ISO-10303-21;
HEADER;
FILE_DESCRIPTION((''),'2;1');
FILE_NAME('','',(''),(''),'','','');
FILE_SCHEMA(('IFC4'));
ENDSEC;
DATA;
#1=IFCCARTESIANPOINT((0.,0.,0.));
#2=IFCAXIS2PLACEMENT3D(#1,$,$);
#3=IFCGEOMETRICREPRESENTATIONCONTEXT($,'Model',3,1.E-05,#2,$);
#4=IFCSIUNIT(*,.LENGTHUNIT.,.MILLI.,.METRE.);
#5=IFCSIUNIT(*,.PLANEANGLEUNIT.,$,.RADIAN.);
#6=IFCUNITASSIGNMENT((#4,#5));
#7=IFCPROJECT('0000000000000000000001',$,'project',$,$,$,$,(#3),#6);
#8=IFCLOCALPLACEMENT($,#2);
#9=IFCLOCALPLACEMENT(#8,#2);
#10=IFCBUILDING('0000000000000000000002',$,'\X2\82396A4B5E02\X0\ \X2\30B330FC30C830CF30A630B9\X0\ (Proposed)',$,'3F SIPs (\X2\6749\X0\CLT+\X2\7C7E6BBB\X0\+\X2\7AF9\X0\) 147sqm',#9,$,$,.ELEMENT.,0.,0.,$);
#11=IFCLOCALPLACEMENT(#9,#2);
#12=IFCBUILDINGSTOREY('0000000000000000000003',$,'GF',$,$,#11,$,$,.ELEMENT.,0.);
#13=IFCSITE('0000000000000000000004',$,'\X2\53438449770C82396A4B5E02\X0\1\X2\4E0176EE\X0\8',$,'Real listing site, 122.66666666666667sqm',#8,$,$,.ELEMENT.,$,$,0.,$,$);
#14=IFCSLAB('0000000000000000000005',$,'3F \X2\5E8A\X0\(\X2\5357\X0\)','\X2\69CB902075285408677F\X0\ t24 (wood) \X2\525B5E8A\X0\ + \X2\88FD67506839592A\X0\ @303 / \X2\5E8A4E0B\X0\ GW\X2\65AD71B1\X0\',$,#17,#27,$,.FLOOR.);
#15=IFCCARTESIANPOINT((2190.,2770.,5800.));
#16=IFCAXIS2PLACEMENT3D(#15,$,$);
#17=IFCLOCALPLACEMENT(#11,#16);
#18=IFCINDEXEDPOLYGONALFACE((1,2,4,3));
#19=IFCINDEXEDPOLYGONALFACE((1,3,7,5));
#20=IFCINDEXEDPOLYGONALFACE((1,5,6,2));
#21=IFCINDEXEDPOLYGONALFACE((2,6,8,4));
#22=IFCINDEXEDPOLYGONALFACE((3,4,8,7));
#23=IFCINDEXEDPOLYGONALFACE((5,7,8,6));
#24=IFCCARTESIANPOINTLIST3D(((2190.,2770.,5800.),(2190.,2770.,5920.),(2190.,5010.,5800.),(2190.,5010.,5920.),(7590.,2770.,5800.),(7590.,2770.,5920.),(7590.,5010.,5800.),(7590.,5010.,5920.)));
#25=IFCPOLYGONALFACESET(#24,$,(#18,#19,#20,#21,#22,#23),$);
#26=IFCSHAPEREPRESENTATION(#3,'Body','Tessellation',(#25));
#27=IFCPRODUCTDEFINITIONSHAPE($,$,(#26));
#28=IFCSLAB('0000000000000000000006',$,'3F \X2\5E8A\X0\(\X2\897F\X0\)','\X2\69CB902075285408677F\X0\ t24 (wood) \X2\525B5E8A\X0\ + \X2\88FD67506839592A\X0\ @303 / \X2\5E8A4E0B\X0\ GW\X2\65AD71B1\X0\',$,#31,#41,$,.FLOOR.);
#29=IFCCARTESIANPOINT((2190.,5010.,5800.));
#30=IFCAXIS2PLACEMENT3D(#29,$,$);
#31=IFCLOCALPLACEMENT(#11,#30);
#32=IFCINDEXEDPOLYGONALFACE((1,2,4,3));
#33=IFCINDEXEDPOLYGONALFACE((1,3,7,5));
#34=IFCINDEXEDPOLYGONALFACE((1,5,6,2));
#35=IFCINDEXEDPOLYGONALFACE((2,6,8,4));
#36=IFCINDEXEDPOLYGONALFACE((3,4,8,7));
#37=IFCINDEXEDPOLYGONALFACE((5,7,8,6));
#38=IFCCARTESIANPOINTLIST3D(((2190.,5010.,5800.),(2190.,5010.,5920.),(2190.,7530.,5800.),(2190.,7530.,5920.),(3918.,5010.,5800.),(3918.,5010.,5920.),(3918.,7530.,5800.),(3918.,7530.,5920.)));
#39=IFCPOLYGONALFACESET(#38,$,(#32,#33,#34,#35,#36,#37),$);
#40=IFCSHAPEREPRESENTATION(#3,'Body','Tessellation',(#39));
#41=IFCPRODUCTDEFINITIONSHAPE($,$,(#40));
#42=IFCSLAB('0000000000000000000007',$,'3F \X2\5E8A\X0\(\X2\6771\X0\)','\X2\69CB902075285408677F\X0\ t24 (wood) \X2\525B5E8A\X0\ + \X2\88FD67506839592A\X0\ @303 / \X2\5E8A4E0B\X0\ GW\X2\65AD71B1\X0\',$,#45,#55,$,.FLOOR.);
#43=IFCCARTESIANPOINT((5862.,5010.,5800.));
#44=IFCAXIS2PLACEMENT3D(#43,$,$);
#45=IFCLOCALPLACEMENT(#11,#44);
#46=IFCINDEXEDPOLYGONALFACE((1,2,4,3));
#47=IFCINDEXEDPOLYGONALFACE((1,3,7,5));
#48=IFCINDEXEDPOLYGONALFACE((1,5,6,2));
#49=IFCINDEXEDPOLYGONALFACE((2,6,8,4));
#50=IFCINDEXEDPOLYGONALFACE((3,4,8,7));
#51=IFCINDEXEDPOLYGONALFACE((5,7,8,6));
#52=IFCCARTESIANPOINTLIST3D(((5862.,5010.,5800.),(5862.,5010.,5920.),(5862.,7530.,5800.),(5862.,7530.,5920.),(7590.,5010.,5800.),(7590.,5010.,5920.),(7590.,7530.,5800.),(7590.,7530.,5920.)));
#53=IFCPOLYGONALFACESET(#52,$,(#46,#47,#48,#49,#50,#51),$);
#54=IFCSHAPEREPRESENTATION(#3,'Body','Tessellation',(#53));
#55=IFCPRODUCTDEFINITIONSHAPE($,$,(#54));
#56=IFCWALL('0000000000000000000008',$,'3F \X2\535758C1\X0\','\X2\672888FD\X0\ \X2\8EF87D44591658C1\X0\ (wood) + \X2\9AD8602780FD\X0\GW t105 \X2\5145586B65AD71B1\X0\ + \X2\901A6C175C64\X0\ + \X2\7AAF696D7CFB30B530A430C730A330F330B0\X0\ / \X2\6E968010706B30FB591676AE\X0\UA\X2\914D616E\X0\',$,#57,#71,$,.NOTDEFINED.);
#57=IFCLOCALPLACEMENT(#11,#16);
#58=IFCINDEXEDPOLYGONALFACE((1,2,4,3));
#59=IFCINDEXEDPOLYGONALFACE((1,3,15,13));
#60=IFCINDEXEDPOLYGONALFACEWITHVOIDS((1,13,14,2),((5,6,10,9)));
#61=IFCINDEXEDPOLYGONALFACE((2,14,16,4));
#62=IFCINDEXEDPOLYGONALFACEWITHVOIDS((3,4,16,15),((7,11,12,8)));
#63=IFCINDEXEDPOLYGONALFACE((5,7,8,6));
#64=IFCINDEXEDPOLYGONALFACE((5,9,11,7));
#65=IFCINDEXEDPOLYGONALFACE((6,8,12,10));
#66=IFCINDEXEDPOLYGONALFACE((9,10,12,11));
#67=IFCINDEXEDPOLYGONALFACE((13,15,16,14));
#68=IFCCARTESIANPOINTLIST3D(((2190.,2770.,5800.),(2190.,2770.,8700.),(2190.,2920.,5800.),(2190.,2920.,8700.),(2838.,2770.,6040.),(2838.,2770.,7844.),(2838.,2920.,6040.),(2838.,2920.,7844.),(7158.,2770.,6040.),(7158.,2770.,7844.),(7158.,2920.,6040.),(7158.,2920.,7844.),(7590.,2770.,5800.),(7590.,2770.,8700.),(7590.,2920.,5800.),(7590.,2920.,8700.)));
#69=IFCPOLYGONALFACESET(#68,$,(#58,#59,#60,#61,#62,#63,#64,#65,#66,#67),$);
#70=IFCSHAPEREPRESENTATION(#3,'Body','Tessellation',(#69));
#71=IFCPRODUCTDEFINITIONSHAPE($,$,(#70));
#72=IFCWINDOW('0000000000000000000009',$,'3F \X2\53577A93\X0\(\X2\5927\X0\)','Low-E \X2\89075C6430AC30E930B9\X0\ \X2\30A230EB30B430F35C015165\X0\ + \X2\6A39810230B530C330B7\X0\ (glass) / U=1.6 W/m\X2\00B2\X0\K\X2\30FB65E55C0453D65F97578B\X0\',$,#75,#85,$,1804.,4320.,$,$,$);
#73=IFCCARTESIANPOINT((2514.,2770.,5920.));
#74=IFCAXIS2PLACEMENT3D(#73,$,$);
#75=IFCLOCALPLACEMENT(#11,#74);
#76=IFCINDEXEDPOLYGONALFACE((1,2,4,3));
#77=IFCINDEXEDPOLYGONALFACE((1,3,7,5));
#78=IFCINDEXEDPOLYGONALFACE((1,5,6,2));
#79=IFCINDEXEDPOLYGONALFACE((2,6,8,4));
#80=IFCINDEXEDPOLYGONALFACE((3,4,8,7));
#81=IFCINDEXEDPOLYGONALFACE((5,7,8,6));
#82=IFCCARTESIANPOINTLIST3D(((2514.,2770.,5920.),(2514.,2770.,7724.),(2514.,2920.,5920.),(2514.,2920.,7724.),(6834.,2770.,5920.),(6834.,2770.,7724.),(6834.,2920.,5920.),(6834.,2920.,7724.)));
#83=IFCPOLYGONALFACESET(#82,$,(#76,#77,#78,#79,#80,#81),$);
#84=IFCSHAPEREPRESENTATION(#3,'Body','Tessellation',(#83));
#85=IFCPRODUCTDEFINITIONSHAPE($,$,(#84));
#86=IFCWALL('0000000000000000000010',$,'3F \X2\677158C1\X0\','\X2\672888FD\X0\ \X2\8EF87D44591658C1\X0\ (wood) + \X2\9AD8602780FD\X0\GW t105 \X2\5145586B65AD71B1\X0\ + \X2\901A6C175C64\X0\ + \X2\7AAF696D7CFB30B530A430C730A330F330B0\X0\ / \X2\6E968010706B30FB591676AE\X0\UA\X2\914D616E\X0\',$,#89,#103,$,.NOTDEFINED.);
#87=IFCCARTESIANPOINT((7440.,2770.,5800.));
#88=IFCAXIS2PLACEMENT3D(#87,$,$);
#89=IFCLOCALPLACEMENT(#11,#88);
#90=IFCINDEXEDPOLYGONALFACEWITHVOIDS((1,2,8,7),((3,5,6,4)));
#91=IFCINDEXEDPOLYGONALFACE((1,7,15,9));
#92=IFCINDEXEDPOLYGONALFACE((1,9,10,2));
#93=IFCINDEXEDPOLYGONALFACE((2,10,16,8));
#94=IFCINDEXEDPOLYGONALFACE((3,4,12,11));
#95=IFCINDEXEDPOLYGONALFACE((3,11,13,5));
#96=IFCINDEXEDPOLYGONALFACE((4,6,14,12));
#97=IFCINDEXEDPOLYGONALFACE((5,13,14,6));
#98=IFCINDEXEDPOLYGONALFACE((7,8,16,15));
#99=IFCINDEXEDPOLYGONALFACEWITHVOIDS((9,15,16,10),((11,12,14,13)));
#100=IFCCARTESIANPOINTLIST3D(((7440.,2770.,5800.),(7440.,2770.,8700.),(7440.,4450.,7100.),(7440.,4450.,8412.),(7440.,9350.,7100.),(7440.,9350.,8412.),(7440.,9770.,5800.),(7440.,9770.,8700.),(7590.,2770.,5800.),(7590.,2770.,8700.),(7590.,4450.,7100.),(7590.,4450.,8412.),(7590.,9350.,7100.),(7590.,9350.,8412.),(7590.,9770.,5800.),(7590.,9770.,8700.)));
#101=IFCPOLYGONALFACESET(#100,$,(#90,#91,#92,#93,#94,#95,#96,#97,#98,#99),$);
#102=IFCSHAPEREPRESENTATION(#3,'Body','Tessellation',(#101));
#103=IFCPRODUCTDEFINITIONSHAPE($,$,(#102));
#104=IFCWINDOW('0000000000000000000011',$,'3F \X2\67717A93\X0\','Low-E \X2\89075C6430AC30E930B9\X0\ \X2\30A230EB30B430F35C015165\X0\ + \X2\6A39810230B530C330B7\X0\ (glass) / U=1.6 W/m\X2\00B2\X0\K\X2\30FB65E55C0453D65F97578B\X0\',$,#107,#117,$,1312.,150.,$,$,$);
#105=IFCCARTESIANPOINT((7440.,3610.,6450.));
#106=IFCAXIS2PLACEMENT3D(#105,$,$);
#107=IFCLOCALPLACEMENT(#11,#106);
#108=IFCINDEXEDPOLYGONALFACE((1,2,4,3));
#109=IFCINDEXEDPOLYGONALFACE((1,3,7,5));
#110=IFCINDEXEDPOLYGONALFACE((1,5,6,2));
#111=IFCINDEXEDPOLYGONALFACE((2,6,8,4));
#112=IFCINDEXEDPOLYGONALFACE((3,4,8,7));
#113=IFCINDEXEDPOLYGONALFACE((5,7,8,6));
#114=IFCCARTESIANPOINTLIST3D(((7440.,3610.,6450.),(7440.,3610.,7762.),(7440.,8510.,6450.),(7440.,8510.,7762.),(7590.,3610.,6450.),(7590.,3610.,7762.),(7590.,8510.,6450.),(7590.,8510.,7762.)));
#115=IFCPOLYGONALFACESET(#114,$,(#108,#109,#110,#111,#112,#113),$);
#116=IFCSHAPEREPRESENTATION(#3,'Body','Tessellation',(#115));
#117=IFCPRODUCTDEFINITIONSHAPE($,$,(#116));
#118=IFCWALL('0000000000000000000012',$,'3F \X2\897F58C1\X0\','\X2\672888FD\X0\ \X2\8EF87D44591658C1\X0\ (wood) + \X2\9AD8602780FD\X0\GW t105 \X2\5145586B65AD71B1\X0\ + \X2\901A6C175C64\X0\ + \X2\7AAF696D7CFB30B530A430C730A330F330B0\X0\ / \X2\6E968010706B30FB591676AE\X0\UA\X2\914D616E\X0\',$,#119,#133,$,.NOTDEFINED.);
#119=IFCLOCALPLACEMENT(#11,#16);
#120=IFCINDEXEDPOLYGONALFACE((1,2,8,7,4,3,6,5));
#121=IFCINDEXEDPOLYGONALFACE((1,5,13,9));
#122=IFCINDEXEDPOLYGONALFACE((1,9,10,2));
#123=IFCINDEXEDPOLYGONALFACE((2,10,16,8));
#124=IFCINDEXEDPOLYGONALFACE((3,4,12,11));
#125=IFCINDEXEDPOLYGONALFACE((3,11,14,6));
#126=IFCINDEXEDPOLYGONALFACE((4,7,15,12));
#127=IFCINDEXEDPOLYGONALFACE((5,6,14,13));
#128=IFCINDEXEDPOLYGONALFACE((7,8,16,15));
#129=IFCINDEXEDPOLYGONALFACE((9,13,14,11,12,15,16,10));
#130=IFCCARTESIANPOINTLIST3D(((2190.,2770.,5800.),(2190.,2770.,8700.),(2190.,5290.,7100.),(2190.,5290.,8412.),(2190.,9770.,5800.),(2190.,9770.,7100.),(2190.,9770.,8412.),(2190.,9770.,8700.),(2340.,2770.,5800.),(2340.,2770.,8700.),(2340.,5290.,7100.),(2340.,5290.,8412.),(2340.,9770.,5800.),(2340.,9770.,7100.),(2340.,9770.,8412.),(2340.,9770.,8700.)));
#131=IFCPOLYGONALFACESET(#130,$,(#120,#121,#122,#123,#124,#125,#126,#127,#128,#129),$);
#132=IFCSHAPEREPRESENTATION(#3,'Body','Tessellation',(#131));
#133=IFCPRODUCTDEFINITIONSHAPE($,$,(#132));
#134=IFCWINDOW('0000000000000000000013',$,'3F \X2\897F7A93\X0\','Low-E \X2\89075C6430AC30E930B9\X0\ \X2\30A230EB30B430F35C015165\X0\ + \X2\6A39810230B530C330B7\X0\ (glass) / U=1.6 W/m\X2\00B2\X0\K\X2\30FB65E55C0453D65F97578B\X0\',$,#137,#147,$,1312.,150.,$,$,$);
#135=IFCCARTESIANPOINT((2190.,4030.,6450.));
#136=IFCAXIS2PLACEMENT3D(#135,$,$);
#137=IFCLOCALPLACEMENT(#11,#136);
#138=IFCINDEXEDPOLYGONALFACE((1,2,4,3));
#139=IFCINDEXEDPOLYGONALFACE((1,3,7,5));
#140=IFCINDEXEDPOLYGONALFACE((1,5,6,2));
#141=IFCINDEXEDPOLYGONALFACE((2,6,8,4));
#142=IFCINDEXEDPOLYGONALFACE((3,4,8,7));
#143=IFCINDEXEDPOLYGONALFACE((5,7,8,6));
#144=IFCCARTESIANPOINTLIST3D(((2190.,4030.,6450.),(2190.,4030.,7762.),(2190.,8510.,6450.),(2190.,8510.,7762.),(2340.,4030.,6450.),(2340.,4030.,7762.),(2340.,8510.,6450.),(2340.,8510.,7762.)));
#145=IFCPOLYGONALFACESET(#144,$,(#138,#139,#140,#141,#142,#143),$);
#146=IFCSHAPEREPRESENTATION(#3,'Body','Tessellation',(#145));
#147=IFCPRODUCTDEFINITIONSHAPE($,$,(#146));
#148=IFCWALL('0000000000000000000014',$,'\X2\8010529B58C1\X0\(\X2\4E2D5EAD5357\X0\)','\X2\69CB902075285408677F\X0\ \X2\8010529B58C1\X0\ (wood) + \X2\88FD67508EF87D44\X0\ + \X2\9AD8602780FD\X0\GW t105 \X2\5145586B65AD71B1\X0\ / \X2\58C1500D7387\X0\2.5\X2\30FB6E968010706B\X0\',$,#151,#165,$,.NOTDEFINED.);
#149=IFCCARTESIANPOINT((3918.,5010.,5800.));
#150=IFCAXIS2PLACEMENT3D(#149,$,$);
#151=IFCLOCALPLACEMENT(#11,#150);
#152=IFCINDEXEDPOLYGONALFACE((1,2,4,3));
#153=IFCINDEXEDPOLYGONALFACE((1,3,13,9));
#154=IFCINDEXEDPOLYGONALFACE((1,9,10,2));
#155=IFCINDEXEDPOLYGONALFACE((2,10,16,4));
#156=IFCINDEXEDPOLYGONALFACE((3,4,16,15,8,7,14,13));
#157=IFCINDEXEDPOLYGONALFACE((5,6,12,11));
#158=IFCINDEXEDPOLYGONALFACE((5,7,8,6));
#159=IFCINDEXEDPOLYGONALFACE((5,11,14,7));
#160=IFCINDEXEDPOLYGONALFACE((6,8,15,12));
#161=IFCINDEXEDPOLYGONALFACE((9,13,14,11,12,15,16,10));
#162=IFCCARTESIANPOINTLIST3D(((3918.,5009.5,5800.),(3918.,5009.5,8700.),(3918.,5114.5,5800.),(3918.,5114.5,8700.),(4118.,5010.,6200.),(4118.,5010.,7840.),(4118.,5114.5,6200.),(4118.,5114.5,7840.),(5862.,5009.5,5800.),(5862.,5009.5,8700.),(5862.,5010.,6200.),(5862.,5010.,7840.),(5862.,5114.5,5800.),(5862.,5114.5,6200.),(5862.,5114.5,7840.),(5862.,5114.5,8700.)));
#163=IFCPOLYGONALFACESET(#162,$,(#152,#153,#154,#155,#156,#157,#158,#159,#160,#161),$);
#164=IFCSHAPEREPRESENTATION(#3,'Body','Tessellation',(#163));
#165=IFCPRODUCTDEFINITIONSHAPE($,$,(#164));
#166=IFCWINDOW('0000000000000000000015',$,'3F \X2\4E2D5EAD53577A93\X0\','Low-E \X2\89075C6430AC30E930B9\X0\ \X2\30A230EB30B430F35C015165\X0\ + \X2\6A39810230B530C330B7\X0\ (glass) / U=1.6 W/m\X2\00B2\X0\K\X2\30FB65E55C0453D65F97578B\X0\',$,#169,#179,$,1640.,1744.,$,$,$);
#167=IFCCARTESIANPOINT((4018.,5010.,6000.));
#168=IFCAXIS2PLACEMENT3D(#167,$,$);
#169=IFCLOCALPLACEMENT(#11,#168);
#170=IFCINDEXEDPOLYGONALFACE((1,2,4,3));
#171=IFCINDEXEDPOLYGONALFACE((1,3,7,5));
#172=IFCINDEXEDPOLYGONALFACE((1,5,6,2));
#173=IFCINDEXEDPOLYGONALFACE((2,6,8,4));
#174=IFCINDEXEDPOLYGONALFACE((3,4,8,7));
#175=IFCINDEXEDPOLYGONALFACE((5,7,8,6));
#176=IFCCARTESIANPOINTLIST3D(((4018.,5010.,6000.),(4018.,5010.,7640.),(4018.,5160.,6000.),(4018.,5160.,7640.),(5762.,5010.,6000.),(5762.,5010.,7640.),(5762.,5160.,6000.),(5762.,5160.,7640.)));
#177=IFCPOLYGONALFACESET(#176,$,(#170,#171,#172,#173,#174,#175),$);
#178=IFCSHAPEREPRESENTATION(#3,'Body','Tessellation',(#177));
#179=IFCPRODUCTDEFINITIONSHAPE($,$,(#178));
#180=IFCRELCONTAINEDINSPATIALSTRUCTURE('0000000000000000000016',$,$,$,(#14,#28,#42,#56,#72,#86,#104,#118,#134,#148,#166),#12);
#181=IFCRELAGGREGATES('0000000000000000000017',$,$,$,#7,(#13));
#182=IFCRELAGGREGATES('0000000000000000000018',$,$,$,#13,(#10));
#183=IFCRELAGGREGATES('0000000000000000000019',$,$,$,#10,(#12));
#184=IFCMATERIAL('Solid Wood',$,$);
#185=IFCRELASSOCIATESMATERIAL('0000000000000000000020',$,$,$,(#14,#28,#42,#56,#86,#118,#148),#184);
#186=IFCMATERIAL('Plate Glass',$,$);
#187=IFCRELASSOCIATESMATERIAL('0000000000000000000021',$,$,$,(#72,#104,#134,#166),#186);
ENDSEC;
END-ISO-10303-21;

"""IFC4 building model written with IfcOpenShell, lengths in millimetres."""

from ifc_helpers import new_model, si_unit, frame, frame_2d, origin, place, context, project, spatial, rectangle, extrude, material, element, fill, save


model = new_model("IFC4")

# Units and contexts
model_context = context("Model", 3, precision=1e-05, world=origin())
ifc_project = project(units=[si_unit("LENGTHUNIT", "METRE", prefix="MILLI"), si_unit("PLANEANGLEUNIT", "RADIAN")], contexts=[model_context])

# Site, building, storey
site_placement = place(None, origin())
site = spatial("IfcSite", under=ifc_project, at=site_placement, Name="千葉県船橋市1丁目8", ObjectType="Real listing site, 122.66666666666667sqm", CompositionType="ELEMENT", RefElevation=0.0)
building_placement = place(site_placement, origin())
building = spatial("IfcBuilding", under=site, at=building_placement, Name="船橋市 コートハウス (Proposed)", ObjectType="3F SIPs (杉CLT+籾殻+竹) 147sqm", CompositionType="ELEMENT", ElevationOfRefHeight=0.0, ElevationOfTerrain=0.0)
storey_placement = place(building_placement, origin())
storey = spatial("IfcBuildingStorey", under=building, at=storey_placement, Name="GF", CompositionType="ELEMENT", Elevation=0.0)

# Slabs
ifc_material_1 = material(Name="Solid Wood")
slab_1_placement = place(storey_placement, frame((2190.0, 2770.0, 5800.0)))
element("IfcSlab", 1, at=slab_1_placement, inside=storey, material=ifc_material_1, Name="3F 床(南)", Description="構造用合板 t24 (wood) 剛床 + 製材根太 @303 / 床下 GW断熱", PredefinedType="FLOOR", context=model_context, shape_type="SweptSolid", body=[
    extrude(rectangle(XDim=5400.0, YDim=2240.0, at=frame_2d((2700.0, 1120.0))), frame((2190.0, 2770.0, 5800.0)), (0.0, 0.0, 1.0), 120.0),
])
slab_2_placement = place(storey_placement, frame((2190.0, 5010.0, 5800.0)))
element("IfcSlab", 2, at=slab_2_placement, inside=storey, material=ifc_material_1, Name="3F 床(西)", Description="構造用合板 t24 (wood) 剛床 + 製材根太 @303 / 床下 GW断熱", PredefinedType="FLOOR", context=model_context, shape_type="SweptSolid", body=[
    extrude(rectangle(XDim=1728.0, YDim=2520.0, at=frame_2d((864.0, 1260.0))), frame((2190.0, 5010.0, 5800.0)), (0.0, 0.0, 1.0), 120.0),
])
slab_3_placement = place(storey_placement, frame((5862.0, 5010.0, 5800.0)))
element("IfcSlab", 3, at=slab_3_placement, inside=storey, material=ifc_material_1, Name="3F 床(東)", Description="構造用合板 t24 (wood) 剛床 + 製材根太 @303 / 床下 GW断熱", PredefinedType="FLOOR", context=model_context, shape_type="SweptSolid", body=[
    extrude(rectangle(XDim=1728.0, YDim=2520.0, at=frame_2d((864.0, 1260.0))), frame((5862.0, 5010.0, 5800.0)), (0.0, 0.0, 1.0), 120.0),
])

# Walls, openings, windows
wall_1_placement = place(storey_placement, frame((2190.0, 2770.0, 5800.0)))
wall_1 = element("IfcWall", 4, at=wall_1_placement, inside=storey, material=ifc_material_1, Name="3F 南壁", Description="木製 軸組外壁 (wood) + 高性能GW t105 充填断熱 + 通気層 + 窯業系サイディング / 準耐火・外皮UA配慮", PredefinedType="NOTDEFINED", context=model_context, shape_type="SweptSolid", body=[
    extrude(rectangle(XDim=5400.0, YDim=150.0, at=frame_2d((2700.0, 75.0))), frame((2190.0, 2770.0, 5800.0)), (0.0, 0.0, 1.0), 2900.0),
])
opening_1_placement = place(storey_placement, frame((2514.0, 2770.0, 5920.0)))
opening_1 = element("IfcOpeningElement", 5, at=opening_1_placement, cuts=wall_1, PredefinedType="NOTDEFINED", context=model_context, shape_type="SweptSolid", body=[
    extrude(rectangle(XDim=4320.0, YDim=150.0, at=frame_2d((2160.0, 75.0))), frame((2514.0, 2770.0, 5920.0)), (0.0, 0.0, 1.0), 1804.0),
])
ifc_material_2 = material(Name="Plate Glass")
window_1_placement = place(storey_placement, frame((2514.0, 2770.0, 5920.0)))
window_1 = element("IfcWindow", 6, at=window_1_placement, inside=storey, material=ifc_material_2, Name="3F 南窓(大)", Description="Low-E 複層ガラス アルゴン封入 + 樹脂サッシ (glass) / U=1.6 W/m²K・日射取得型", OverallHeight=1804.0, OverallWidth=4320.0, context=model_context, shape_type="SweptSolid", body=[
    extrude(rectangle(XDim=4320.0, YDim=150.0, at=frame_2d((2160.0, 75.0))), frame((2514.0, 2770.0, 5920.0)), (0.0, 0.0, 1.0), 1804.0),
])
fill(opening_1, window_1)
wall_2_placement = place(storey_placement, frame((7440.0, 2770.0, 5800.0)))
wall_2 = element("IfcWall", 7, at=wall_2_placement, inside=storey, material=ifc_material_1, Name="3F 東壁", Description="木製 軸組外壁 (wood) + 高性能GW t105 充填断熱 + 通気層 + 窯業系サイディング / 準耐火・外皮UA配慮", PredefinedType="NOTDEFINED", context=model_context, shape_type="SweptSolid", body=[
    extrude(rectangle(XDim=150.0, YDim=7000.0, at=frame_2d((75.0, 3500.0))), frame((7440.0, 2770.0, 5800.0)), (0.0, 0.0, 1.0), 2900.0),
])
opening_2_placement = place(storey_placement, frame((7440.0, 3610.0, 6450.0)))
opening_2 = element("IfcOpeningElement", 8, at=opening_2_placement, cuts=wall_2, PredefinedType="NOTDEFINED", context=model_context, shape_type="SweptSolid", body=[
    extrude(rectangle(XDim=150.0, YDim=4900.0, at=frame_2d((75.0, 2450.0))), frame((7440.0, 3610.0, 6450.0)), (0.0, 0.0, 1.0), 1312.0),
])
window_2_placement = place(storey_placement, frame((7440.0, 3610.0, 6450.0)))
window_2 = element("IfcWindow", 9, at=window_2_placement, inside=storey, material=ifc_material_2, Name="3F 東窓", Description="Low-E 複層ガラス アルゴン封入 + 樹脂サッシ (glass) / U=1.6 W/m²K・日射取得型", OverallHeight=1312.0, OverallWidth=150.0, context=model_context, shape_type="SweptSolid", body=[
    extrude(rectangle(XDim=150.0, YDim=4900.0, at=frame_2d((75.0, 2450.0))), frame((7440.0, 3610.0, 6450.0)), (0.0, 0.0, 1.0), 1312.0),
])
fill(opening_2, window_2)
wall_3_placement = place(storey_placement, frame((2190.0, 2770.0, 5800.0)))
wall_3 = element("IfcWall", 10, at=wall_3_placement, inside=storey, material=ifc_material_1, Name="3F 西壁", Description="木製 軸組外壁 (wood) + 高性能GW t105 充填断熱 + 通気層 + 窯業系サイディング / 準耐火・外皮UA配慮", PredefinedType="NOTDEFINED", context=model_context, shape_type="SweptSolid", body=[
    extrude(rectangle(XDim=150.0, YDim=7000.0, at=frame_2d((75.0, 3500.0))), frame((2190.0, 2770.0, 5800.0)), (0.0, 0.0, 1.0), 2900.0),
])
opening_3_placement = place(storey_placement, frame((2190.0, 4030.0, 6450.0)))
opening_3 = element("IfcOpeningElement", 11, at=opening_3_placement, cuts=wall_3, PredefinedType="NOTDEFINED", context=model_context, shape_type="SweptSolid", body=[
    extrude(rectangle(XDim=150.0, YDim=4480.0, at=frame_2d((75.0, 2240.0))), frame((2190.0, 4030.0, 6450.0)), (0.0, 0.0, 1.0), 1312.0),
])
window_3_placement = place(storey_placement, frame((2190.0, 4030.0, 6450.0)))
window_3 = element("IfcWindow", 12, at=window_3_placement, inside=storey, material=ifc_material_2, Name="3F 西窓", Description="Low-E 複層ガラス アルゴン封入 + 樹脂サッシ (glass) / U=1.6 W/m²K・日射取得型", OverallHeight=1312.0, OverallWidth=150.0, context=model_context, shape_type="SweptSolid", body=[
    extrude(rectangle(XDim=150.0, YDim=4480.0, at=frame_2d((75.0, 2240.0))), frame((2190.0, 4030.0, 6450.0)), (0.0, 0.0, 1.0), 1312.0),
])
fill(opening_3, window_3)
wall_4_placement = place(storey_placement, frame((3918.0, 5010.0, 5800.0)))
wall_4 = element("IfcWall", 13, at=wall_4_placement, inside=storey, material=ifc_material_1, Name="耐力壁(中庭南)", Description="構造用合板 耐力壁 (wood) + 製材軸組 + 高性能GW t105 充填断熱 / 壁倍率2.5・準耐火", PredefinedType="NOTDEFINED", context=model_context, shape_type="SweptSolid", body=[
    extrude(rectangle(XDim=1944.0, YDim=105.0, at=frame_2d((972.0, 52.0))), frame((3918.0, 5010.0, 5800.0)), (0.0, 0.0, 1.0), 2900.0),
])
opening_4_placement = place(storey_placement, frame((4018.0, 5010.0, 6000.0)))
opening_4 = element("IfcOpeningElement", 14, at=opening_4_placement, cuts=wall_4, PredefinedType="NOTDEFINED", context=model_context, shape_type="SweptSolid", body=[
    extrude(rectangle(XDim=1744.0, YDim=150.0, at=frame_2d((872.0, 75.0))), frame((4018.0, 5010.0, 6000.0)), (0.0, 0.0, 1.0), 1640.0),
])
window_4_placement = place(storey_placement, frame((4018.0, 5010.0, 6000.0)))
window_4 = element("IfcWindow", 15, at=window_4_placement, inside=storey, material=ifc_material_2, Name="3F 中庭南窓", Description="Low-E 複層ガラス アルゴン封入 + 樹脂サッシ (glass) / U=1.6 W/m²K・日射取得型", OverallHeight=1640.0, OverallWidth=1744.0, context=model_context, shape_type="SweptSolid", body=[
    extrude(rectangle(XDim=1744.0, YDim=150.0, at=frame_2d((872.0, 75.0))), frame((4018.0, 5010.0, 6000.0)), (0.0, 0.0, 1.0), 1640.0),
])
fill(opening_4, window_4)

save(model, "model.ifc")
